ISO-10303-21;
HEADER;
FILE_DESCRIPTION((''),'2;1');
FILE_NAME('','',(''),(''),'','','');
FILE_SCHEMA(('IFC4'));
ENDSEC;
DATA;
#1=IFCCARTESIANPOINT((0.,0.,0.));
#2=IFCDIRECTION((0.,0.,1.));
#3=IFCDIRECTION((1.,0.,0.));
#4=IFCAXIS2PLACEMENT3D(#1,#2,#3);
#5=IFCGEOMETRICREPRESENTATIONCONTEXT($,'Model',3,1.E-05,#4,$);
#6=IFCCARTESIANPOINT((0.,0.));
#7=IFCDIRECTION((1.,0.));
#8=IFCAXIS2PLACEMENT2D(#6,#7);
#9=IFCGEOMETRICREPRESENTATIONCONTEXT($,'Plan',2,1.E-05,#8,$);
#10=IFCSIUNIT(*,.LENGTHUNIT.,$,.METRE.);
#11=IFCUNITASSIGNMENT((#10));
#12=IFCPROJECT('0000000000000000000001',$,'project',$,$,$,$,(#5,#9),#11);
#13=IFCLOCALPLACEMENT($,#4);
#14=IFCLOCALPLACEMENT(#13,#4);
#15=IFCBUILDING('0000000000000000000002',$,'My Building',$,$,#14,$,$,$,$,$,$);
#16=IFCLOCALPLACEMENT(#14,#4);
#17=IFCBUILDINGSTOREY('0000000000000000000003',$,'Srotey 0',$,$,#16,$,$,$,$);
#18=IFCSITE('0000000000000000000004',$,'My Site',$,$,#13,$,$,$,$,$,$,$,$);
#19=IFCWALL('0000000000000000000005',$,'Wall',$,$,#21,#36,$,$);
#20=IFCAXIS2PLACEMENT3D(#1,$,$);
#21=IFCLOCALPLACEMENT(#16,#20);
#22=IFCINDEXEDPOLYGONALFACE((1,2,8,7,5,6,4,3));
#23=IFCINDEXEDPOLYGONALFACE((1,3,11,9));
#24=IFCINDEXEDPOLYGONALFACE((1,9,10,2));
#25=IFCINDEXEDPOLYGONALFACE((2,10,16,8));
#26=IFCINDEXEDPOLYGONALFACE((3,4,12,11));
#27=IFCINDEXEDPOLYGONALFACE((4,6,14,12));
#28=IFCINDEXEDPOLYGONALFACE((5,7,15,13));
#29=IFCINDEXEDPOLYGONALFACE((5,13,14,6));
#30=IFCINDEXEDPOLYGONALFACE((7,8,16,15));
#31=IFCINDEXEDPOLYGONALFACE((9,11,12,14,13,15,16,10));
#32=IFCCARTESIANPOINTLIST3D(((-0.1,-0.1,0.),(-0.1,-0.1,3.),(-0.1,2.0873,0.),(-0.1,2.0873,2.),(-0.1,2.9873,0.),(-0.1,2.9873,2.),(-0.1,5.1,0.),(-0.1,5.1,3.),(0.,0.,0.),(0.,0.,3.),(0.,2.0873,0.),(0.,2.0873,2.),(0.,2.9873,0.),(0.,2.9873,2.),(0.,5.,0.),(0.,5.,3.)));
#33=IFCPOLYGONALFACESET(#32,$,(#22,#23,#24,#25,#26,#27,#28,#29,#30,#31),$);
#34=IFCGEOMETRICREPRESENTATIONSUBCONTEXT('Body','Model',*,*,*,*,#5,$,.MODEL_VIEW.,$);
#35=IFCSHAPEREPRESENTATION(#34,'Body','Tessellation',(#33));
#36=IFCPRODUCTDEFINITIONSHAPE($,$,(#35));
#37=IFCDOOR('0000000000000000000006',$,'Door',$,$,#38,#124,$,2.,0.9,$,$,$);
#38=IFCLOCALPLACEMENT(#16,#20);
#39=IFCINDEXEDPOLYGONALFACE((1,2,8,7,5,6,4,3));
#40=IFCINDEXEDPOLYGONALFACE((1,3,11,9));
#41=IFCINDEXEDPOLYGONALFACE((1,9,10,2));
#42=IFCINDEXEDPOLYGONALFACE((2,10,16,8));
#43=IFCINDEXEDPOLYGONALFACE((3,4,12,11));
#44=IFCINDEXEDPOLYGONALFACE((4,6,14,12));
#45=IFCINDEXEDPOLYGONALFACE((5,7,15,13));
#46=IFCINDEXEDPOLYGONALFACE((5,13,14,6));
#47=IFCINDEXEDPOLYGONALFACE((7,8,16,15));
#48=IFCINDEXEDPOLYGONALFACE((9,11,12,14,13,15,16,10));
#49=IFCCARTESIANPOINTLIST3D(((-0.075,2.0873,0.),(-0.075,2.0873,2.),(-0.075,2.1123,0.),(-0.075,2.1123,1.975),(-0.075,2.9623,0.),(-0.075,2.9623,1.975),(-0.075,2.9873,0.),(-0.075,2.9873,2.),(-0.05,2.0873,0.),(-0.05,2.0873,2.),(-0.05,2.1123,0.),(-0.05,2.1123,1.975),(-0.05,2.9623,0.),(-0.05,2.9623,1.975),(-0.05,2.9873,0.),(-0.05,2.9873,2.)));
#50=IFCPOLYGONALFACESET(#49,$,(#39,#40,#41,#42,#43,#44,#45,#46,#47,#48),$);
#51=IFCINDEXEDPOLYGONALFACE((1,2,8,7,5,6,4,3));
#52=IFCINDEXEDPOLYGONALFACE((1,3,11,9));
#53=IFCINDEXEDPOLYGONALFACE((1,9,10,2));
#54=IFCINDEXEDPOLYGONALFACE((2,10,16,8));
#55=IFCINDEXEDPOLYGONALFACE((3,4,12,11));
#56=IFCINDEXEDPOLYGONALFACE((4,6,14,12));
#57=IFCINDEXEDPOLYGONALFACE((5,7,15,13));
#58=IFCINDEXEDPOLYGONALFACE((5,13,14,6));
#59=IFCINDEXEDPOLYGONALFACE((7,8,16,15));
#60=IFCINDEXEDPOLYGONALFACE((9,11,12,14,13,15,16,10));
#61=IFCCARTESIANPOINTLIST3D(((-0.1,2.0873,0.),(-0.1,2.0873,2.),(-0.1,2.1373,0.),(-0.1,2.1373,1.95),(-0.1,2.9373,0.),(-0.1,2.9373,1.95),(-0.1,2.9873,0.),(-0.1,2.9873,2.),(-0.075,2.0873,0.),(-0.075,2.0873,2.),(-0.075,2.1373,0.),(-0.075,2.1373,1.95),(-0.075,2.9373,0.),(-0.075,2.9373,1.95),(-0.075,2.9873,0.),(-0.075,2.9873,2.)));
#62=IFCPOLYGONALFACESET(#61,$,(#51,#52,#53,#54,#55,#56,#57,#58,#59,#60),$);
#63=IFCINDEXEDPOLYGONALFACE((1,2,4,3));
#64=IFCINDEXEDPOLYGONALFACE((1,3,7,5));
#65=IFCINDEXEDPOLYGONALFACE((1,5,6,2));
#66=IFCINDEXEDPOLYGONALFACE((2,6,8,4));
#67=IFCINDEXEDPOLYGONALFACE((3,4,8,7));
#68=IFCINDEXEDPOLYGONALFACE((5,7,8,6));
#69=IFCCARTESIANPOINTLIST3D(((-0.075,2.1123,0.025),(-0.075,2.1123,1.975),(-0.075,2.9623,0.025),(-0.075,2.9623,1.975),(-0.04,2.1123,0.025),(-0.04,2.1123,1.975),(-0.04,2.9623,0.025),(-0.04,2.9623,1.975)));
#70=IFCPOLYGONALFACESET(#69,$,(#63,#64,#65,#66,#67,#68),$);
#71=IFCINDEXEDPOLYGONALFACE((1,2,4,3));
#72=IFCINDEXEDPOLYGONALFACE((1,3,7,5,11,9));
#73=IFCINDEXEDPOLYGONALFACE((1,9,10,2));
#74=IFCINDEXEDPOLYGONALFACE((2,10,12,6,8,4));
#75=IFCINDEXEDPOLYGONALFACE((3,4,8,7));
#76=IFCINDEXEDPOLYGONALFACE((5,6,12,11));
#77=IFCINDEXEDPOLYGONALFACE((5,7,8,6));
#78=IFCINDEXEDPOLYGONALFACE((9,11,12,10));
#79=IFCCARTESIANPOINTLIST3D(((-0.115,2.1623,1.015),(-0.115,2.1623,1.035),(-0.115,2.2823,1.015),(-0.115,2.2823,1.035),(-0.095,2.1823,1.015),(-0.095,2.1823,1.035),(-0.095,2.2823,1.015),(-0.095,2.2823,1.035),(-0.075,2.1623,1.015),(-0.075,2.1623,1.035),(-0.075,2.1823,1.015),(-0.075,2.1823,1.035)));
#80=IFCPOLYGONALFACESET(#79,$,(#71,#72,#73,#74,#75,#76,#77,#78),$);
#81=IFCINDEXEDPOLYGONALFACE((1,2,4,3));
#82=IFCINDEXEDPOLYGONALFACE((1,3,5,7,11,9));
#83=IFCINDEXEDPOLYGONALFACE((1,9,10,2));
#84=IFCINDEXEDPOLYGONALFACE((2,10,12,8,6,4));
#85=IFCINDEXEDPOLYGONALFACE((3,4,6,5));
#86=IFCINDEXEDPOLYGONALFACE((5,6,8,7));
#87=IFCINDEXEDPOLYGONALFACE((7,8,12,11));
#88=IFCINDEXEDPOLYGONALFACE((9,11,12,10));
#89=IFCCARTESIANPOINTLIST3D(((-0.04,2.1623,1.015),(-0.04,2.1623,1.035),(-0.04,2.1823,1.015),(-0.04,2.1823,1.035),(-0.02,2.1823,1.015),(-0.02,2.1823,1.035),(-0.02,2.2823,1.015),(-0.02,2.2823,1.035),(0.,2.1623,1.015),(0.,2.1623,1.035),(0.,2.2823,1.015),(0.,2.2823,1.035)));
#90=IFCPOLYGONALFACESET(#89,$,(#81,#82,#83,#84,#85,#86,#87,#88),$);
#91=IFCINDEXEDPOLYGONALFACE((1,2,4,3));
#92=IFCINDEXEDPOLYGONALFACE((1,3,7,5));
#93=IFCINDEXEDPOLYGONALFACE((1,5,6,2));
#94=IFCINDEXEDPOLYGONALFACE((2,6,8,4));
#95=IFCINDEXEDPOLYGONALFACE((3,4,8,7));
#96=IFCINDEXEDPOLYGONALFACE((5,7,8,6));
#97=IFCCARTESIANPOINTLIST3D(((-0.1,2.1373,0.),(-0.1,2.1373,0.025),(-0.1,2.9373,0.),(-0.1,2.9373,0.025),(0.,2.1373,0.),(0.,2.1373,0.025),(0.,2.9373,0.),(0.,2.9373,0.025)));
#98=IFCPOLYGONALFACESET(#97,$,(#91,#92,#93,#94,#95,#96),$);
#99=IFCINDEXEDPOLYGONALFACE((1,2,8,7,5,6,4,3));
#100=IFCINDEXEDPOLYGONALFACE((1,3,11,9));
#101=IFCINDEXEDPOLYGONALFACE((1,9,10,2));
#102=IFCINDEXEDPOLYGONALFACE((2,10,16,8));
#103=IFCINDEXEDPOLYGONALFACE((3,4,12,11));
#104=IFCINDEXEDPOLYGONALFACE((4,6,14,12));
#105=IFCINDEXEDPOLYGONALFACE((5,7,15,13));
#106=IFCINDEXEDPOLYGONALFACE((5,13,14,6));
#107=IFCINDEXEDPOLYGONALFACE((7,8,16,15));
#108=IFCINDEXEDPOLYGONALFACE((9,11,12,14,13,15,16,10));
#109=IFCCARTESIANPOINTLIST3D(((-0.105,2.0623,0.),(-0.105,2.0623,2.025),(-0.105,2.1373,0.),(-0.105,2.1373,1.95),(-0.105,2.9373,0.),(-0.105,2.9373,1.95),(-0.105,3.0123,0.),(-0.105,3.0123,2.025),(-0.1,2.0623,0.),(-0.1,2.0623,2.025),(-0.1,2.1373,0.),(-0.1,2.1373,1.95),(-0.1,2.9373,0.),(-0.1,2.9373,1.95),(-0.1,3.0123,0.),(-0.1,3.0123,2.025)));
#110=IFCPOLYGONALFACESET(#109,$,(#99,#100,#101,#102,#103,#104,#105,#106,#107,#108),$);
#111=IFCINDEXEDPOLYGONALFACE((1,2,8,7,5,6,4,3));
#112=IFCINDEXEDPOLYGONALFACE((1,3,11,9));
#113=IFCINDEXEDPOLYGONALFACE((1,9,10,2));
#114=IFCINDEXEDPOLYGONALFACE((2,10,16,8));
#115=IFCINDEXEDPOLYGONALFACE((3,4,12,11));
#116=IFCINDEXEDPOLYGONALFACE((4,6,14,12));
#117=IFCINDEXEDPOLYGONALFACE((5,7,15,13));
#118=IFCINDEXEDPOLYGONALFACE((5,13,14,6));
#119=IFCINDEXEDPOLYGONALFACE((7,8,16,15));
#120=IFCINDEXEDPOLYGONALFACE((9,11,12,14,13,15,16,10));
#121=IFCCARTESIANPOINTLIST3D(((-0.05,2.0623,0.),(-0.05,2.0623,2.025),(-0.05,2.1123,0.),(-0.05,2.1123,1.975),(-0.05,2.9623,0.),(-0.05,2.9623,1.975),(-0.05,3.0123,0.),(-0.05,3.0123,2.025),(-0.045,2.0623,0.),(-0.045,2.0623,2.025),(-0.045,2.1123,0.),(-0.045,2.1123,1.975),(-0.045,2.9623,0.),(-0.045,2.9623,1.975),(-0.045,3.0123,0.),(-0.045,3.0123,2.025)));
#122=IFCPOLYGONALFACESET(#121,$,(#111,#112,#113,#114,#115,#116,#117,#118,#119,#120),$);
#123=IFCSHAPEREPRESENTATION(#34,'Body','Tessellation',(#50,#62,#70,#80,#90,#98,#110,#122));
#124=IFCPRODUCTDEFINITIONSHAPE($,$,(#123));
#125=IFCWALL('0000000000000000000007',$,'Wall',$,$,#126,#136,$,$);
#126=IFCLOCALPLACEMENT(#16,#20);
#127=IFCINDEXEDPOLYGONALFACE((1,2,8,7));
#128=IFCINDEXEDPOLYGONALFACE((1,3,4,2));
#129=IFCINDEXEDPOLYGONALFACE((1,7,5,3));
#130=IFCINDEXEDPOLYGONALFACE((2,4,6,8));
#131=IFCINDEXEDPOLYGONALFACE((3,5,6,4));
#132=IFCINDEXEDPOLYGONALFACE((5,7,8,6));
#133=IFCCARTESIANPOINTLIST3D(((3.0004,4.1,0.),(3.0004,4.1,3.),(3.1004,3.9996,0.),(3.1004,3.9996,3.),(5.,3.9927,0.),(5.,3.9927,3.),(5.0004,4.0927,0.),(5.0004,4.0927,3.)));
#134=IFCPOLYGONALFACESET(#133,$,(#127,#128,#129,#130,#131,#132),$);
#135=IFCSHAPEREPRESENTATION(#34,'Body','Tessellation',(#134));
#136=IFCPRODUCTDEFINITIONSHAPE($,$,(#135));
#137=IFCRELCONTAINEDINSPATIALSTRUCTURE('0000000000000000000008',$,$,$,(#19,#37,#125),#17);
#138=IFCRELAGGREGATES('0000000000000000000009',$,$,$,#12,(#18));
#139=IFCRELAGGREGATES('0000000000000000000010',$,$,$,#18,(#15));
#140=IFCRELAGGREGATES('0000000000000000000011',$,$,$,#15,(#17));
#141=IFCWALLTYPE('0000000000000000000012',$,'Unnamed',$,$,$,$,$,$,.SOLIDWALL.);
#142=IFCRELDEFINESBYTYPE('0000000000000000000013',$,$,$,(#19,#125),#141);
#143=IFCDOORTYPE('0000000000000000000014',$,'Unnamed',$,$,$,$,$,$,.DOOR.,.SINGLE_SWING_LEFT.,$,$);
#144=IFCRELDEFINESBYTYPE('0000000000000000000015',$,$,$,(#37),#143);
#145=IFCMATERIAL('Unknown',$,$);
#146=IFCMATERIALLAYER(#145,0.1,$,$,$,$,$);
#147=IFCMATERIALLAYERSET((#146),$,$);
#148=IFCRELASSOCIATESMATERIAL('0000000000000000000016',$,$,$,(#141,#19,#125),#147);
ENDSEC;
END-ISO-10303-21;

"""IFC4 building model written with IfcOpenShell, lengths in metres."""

from ifc_helpers import new_model, entity, si_unit, frame, origin_with_axes, origin_2d_with_axis, place, context, subcontext, project, spatial, line, indexed_curve, outline, extrude, shape, source, transform, mapped, material, layer, layer_set, layer_usage, type_object, type_shapes, element, fill, save


model = new_model("IFC4")

# Units and contexts
model_context = context("Model", 3, precision=1e-05, world=origin_with_axes())
plan_context = context("Plan", 2, precision=1e-05, world=origin_2d_with_axis())
body_context_1 = subcontext(model_context, "Body", "Model", "MODEL_VIEW")
body_context_2 = subcontext(plan_context, "Body", "Plan", "PLAN_VIEW")
ifc_project = project(units=[si_unit("LENGTHUNIT", "METRE")], contexts=[model_context, plan_context])

# Site, building, storey
site_placement = place(None, origin_with_axes())
site = spatial("IfcSite", under=ifc_project, at=site_placement, Name="My Site")
building_placement = place(site_placement, origin_with_axes())
building = spatial("IfcBuilding", under=site, at=building_placement, Name="My Building")
storey_placement = place(building_placement, origin_with_axes())
storey = spatial("IfcBuildingStorey", under=building, at=storey_placement, Name="Srotey 0")

# Shared definitions
ifc_material = material(Name="Unknown")
ifc_layer = layer(ifc_material, 0.1)
ifc_layer_set = layer_set([ifc_layer])
wall_type = type_object("IfcWallType", Name="Unnamed", PredefinedType="SOLIDWALL", material=ifc_layer_set)

# Wall, opening, door
ifc_layer_usage_1 = layer_usage(ifc_layer_set, "AXIS2", "POSITIVE", 0.0)
wall_1_placement = place(storey_placement, frame((0.0, 0.0, 0.0), z_axis=(0.0, 0.0, 1.0), x_axis=(0.0, 1.0, 0.0)))
wall_1 = element("IfcWall", 1, at=wall_1_placement, inside=storey, type_object=wall_type, material=ifc_layer_usage_1, Name="Wall", context=body_context_1, shape_type="SweptSolid", body=[
    extrude(outline(indexed_curve([(0.0, 0.0), (-0.1, 0.1), (5.1, 0.1), (5.0, 0.0)], segments=[line(1, 2, 3, 4, 1)])), origin_with_axes(), (0.0, 0.0, 1.0), 3.0),
])
shared_shape_1 = source(origin_with_axes(), body_context_1, "Body", "SweptSolid", [
    extrude(outline(indexed_curve([(0.0, 0.0), (0.9, 0.0), (0.9, 2.0), (0.0, 2.0)], segments=[line(1, 2, 3, 4, 1)])), frame((0.0, -0.6, 0.0), z_axis=(0.0, -1.0, 0.0), x_axis=(1.0, 0.0, 0.0)), (0.0, 0.0, -1.0), 1.2),
])
opening_1_placement = place(wall_1_placement, frame((2.9873, 0.1, 0.0), z_axis=(0.0, 0.0, 1.0), x_axis=(-1.0, 0.0, 0.0)))
opening_1 = element("IfcOpeningElement", 2, at=opening_1_placement, cuts=wall_1, PredefinedType="OPENING", context=body_context_1, shape_type="MappedRepresentation", body=[
    mapped(shared_shape_1, transform((0.0, 0.0, 0.0), x_axis=(1.0, 0.0, 0.0), y_axis=(0.0, 1.0, 0.0), z_axis=(0.0, 0.0, 1.0), scale=1.0)),
])
door_type = type_object("IfcDoorType", Name="Unnamed", OperationType="SINGLE_SWING_LEFT", PredefinedType="DOOR")
shared_shape_2 = source(origin_with_axes(), body_context_1, "Body", "SweptSolid", [
    extrude(outline(indexed_curve([(0.0, 0.0), (0.0, 2.0), (0.9, 2.0), (0.9, 0.0), (0.875, 0.0), (0.875, 1.975), (0.025, 1.975), (0.025, 0.0)], segments=[line(1, 2, 3, 4, 5, 6, 7, 8, 1)])), frame((0.0, 0.025, 0.0), z_axis=(0.0, -1.0, 0.0), x_axis=(1.0, 0.0, 0.0)), (0.0, 0.0, -1.0), 0.025),
    extrude(outline(indexed_curve([(0.0, 0.0), (0.0, 2.0), (0.9, 2.0), (0.9, 0.0), (0.85, 0.0), (0.85, 1.95), (0.05, 1.95), (0.05, 0.0)], segments=[line(1, 2, 3, 4, 5, 6, 7, 8, 1)])), frame((0.0, 0.0, 0.0), z_axis=(0.0, -1.0, 0.0), x_axis=(1.0, 0.0, 0.0)), (0.0, 0.0, -1.0), 0.025),
    extrude(outline(indexed_curve([(0.0, 0.0), (0.85, 0.0), (0.85, 0.035), (0.0, 0.035)], segments=[line(1, 2, 3, 4, 1)])), frame((0.025, 0.025, 0.025), z_axis=(0.0, 0.0, 1.0), x_axis=(1.0, 0.0, 0.0)), (0.0, 0.0, 1.0), 1.95),
    extrude(outline(indexed_curve([(0.0, 0.0), (0.0, -0.04), (-0.12, -0.04), (-0.12, -0.02), (-0.02, -0.02), (-0.02, 0.0)], segments=[line(1, 2, 3, 4, 5, 6, 1)])), frame((0.825, 0.025, 1.015), z_axis=(0.0, 0.0, 1.0), x_axis=(1.0, 0.0, 0.0)), (0.0, 0.0, 1.0), 0.02),
    extrude(outline(indexed_curve([(0.0, 0.0), (0.0, 0.04), (-0.12, 0.04), (-0.12, 0.02), (-0.02, 0.02), (-0.02, 0.0)], segments=[line(1, 2, 3, 4, 5, 6, 1)])), frame((0.825, 0.06, 1.015), z_axis=(0.0, 0.0, 1.0), x_axis=(1.0, 0.0, 0.0)), (0.0, 0.0, 1.0), 0.02),
    extrude(outline(indexed_curve([(0.0, 0.0), (0.8, 0.0), (0.8, 0.1), (0.0, 0.1)], segments=[line(1, 2, 3, 4, 1)])), frame((0.05, 0.0, 0.0), z_axis=(0.0, 0.0, 1.0), x_axis=(1.0, 0.0, 0.0)), (0.0, 0.0, 1.0), 0.025),
    extrude(outline(indexed_curve([(0.0, 0.0), (0.0, 2.025), (0.95, 2.025), (0.95, 0.0), (0.875, 0.0), (0.875, 1.95), (0.075, 1.95), (0.075, 0.0)], segments=[line(1, 2, 3, 4, 5, 6, 7, 8, 1)])), frame((-0.025, -0.005, 0.0), z_axis=(0.0, -1.0, 0.0), x_axis=(1.0, 0.0, 0.0)), (0.0, 0.0, -1.0), 0.005),
    extrude(outline(indexed_curve([(0.0, 0.0), (0.0, 2.025), (0.95, 2.025), (0.95, 0.0), (0.9, 0.0), (0.9, 1.975), (0.05, 1.975), (0.05, 0.0)], segments=[line(1, 2, 3, 4, 5, 6, 7, 8, 1)])), frame((-0.025, 0.05, 0.0), z_axis=(0.0, -1.0, 0.0), x_axis=(1.0, 0.0, 0.0)), (0.0, 0.0, -1.0), 0.005),
])
shared_shape_3 = source(origin_with_axes(), body_context_2, "Body", "Curve2D", [
    entity("IfcIndexedPolyCurve", entity("IfcCartesianPointList2D", [[0.0, 0.0], [0.0, 0.05], [0.025, 0.05], [0.025, 0.025], [0.05, 0.025], [0.05, 0.0]]), [entity("IfcLineIndex", [1, 2, 3, 4, 5, 6, 1])]),
    entity("IfcIndexedPolyCurve", entity("IfcCartesianPointList2D", [[0.9, 0.0], [0.9, 0.05], [0.875, 0.05], [0.875, 0.025], [0.85, 0.025], [0.85, 0.0]]), [entity("IfcLineIndex", [1, 2, 3, 4, 5, 6, 1])]),
    entity("IfcTrimmedCurve", entity("IfcEllipse", entity("IfcAxis2Placement2D", entity("IfcCartesianPoint", [0.06, 0.05]), entity("IfcDirection", [1.0, 0.0])), 0.815, 0.85), [entity("IfcCartesianPoint", [0.875, 0.05])], [entity("IfcCartesianPoint", [0.06, 0.9])], True, "CARTESIAN"),
    entity("IfcIndexedPolyCurve", entity("IfcCartesianPointList2D", [[0.025, 0.05], [0.06, 0.05], [0.06, 0.9], [0.025, 0.9]]), [entity("IfcLineIndex", [1, 2, 3, 4, 1])]),
])
type_shapes(door_type, [shared_shape_2, shared_shape_3])
door_1_placement = place(opening_1_placement, frame((0.0, 0.0, 0.0), z_axis=(0.0, 0.0, 1.0), x_axis=(1.0, 0.0, 0.0)))
door_1 = element("IfcDoor", 3, at=door_1_placement, inside=storey, type_object=door_type, Name="Door", OverallHeight=2.0, OverallWidth=0.9, shapes=[
    shape(body_context_1, "Body", "MappedRepresentation", [mapped(shared_shape_2, transform((0.0, 0.0, 0.0), x_axis=(1.0, 0.0, 0.0), y_axis=(0.0, 1.0, 0.0), z_axis=(0.0, 0.0, 1.0), scale=1.0))]),
    shape(body_context_2, "Body", "MappedRepresentation", [mapped(shared_shape_3, transform((0.0, 0.0, 0.0), x_axis=(1.0, 0.0, 0.0), y_axis=(0.0, 1.0, 0.0), z_axis=(0.0, 0.0, 1.0), scale=1.0))]),
])
fill(opening_1, door_1)

# Wall
ifc_layer_usage_2 = layer_usage(ifc_layer_set, "AXIS2", "POSITIVE", 0.0)
wall_2_placement = place(storey_placement, frame((3.0004, 4.0, 0.0), z_axis=(0.0, 0.0, 1.0), x_axis=(0.999993, -0.003665, 0.0)))
element("IfcWall", 4, at=wall_2_placement, inside=storey, type_object=wall_type, material=ifc_layer_usage_2, Name="Wall", context=body_context_1, shape_type="SweptSolid", body=[
    extrude(outline(indexed_curve([(0.1, 0.0), (-0.0004, 0.1), (1.9997, 0.1), (1.9997, 0.0)], segments=[line(1, 2, 3, 4, 1)])), origin_with_axes(), (0.0, 0.0, 1.0), 3.0),
])

save(model, "model.ifc")
